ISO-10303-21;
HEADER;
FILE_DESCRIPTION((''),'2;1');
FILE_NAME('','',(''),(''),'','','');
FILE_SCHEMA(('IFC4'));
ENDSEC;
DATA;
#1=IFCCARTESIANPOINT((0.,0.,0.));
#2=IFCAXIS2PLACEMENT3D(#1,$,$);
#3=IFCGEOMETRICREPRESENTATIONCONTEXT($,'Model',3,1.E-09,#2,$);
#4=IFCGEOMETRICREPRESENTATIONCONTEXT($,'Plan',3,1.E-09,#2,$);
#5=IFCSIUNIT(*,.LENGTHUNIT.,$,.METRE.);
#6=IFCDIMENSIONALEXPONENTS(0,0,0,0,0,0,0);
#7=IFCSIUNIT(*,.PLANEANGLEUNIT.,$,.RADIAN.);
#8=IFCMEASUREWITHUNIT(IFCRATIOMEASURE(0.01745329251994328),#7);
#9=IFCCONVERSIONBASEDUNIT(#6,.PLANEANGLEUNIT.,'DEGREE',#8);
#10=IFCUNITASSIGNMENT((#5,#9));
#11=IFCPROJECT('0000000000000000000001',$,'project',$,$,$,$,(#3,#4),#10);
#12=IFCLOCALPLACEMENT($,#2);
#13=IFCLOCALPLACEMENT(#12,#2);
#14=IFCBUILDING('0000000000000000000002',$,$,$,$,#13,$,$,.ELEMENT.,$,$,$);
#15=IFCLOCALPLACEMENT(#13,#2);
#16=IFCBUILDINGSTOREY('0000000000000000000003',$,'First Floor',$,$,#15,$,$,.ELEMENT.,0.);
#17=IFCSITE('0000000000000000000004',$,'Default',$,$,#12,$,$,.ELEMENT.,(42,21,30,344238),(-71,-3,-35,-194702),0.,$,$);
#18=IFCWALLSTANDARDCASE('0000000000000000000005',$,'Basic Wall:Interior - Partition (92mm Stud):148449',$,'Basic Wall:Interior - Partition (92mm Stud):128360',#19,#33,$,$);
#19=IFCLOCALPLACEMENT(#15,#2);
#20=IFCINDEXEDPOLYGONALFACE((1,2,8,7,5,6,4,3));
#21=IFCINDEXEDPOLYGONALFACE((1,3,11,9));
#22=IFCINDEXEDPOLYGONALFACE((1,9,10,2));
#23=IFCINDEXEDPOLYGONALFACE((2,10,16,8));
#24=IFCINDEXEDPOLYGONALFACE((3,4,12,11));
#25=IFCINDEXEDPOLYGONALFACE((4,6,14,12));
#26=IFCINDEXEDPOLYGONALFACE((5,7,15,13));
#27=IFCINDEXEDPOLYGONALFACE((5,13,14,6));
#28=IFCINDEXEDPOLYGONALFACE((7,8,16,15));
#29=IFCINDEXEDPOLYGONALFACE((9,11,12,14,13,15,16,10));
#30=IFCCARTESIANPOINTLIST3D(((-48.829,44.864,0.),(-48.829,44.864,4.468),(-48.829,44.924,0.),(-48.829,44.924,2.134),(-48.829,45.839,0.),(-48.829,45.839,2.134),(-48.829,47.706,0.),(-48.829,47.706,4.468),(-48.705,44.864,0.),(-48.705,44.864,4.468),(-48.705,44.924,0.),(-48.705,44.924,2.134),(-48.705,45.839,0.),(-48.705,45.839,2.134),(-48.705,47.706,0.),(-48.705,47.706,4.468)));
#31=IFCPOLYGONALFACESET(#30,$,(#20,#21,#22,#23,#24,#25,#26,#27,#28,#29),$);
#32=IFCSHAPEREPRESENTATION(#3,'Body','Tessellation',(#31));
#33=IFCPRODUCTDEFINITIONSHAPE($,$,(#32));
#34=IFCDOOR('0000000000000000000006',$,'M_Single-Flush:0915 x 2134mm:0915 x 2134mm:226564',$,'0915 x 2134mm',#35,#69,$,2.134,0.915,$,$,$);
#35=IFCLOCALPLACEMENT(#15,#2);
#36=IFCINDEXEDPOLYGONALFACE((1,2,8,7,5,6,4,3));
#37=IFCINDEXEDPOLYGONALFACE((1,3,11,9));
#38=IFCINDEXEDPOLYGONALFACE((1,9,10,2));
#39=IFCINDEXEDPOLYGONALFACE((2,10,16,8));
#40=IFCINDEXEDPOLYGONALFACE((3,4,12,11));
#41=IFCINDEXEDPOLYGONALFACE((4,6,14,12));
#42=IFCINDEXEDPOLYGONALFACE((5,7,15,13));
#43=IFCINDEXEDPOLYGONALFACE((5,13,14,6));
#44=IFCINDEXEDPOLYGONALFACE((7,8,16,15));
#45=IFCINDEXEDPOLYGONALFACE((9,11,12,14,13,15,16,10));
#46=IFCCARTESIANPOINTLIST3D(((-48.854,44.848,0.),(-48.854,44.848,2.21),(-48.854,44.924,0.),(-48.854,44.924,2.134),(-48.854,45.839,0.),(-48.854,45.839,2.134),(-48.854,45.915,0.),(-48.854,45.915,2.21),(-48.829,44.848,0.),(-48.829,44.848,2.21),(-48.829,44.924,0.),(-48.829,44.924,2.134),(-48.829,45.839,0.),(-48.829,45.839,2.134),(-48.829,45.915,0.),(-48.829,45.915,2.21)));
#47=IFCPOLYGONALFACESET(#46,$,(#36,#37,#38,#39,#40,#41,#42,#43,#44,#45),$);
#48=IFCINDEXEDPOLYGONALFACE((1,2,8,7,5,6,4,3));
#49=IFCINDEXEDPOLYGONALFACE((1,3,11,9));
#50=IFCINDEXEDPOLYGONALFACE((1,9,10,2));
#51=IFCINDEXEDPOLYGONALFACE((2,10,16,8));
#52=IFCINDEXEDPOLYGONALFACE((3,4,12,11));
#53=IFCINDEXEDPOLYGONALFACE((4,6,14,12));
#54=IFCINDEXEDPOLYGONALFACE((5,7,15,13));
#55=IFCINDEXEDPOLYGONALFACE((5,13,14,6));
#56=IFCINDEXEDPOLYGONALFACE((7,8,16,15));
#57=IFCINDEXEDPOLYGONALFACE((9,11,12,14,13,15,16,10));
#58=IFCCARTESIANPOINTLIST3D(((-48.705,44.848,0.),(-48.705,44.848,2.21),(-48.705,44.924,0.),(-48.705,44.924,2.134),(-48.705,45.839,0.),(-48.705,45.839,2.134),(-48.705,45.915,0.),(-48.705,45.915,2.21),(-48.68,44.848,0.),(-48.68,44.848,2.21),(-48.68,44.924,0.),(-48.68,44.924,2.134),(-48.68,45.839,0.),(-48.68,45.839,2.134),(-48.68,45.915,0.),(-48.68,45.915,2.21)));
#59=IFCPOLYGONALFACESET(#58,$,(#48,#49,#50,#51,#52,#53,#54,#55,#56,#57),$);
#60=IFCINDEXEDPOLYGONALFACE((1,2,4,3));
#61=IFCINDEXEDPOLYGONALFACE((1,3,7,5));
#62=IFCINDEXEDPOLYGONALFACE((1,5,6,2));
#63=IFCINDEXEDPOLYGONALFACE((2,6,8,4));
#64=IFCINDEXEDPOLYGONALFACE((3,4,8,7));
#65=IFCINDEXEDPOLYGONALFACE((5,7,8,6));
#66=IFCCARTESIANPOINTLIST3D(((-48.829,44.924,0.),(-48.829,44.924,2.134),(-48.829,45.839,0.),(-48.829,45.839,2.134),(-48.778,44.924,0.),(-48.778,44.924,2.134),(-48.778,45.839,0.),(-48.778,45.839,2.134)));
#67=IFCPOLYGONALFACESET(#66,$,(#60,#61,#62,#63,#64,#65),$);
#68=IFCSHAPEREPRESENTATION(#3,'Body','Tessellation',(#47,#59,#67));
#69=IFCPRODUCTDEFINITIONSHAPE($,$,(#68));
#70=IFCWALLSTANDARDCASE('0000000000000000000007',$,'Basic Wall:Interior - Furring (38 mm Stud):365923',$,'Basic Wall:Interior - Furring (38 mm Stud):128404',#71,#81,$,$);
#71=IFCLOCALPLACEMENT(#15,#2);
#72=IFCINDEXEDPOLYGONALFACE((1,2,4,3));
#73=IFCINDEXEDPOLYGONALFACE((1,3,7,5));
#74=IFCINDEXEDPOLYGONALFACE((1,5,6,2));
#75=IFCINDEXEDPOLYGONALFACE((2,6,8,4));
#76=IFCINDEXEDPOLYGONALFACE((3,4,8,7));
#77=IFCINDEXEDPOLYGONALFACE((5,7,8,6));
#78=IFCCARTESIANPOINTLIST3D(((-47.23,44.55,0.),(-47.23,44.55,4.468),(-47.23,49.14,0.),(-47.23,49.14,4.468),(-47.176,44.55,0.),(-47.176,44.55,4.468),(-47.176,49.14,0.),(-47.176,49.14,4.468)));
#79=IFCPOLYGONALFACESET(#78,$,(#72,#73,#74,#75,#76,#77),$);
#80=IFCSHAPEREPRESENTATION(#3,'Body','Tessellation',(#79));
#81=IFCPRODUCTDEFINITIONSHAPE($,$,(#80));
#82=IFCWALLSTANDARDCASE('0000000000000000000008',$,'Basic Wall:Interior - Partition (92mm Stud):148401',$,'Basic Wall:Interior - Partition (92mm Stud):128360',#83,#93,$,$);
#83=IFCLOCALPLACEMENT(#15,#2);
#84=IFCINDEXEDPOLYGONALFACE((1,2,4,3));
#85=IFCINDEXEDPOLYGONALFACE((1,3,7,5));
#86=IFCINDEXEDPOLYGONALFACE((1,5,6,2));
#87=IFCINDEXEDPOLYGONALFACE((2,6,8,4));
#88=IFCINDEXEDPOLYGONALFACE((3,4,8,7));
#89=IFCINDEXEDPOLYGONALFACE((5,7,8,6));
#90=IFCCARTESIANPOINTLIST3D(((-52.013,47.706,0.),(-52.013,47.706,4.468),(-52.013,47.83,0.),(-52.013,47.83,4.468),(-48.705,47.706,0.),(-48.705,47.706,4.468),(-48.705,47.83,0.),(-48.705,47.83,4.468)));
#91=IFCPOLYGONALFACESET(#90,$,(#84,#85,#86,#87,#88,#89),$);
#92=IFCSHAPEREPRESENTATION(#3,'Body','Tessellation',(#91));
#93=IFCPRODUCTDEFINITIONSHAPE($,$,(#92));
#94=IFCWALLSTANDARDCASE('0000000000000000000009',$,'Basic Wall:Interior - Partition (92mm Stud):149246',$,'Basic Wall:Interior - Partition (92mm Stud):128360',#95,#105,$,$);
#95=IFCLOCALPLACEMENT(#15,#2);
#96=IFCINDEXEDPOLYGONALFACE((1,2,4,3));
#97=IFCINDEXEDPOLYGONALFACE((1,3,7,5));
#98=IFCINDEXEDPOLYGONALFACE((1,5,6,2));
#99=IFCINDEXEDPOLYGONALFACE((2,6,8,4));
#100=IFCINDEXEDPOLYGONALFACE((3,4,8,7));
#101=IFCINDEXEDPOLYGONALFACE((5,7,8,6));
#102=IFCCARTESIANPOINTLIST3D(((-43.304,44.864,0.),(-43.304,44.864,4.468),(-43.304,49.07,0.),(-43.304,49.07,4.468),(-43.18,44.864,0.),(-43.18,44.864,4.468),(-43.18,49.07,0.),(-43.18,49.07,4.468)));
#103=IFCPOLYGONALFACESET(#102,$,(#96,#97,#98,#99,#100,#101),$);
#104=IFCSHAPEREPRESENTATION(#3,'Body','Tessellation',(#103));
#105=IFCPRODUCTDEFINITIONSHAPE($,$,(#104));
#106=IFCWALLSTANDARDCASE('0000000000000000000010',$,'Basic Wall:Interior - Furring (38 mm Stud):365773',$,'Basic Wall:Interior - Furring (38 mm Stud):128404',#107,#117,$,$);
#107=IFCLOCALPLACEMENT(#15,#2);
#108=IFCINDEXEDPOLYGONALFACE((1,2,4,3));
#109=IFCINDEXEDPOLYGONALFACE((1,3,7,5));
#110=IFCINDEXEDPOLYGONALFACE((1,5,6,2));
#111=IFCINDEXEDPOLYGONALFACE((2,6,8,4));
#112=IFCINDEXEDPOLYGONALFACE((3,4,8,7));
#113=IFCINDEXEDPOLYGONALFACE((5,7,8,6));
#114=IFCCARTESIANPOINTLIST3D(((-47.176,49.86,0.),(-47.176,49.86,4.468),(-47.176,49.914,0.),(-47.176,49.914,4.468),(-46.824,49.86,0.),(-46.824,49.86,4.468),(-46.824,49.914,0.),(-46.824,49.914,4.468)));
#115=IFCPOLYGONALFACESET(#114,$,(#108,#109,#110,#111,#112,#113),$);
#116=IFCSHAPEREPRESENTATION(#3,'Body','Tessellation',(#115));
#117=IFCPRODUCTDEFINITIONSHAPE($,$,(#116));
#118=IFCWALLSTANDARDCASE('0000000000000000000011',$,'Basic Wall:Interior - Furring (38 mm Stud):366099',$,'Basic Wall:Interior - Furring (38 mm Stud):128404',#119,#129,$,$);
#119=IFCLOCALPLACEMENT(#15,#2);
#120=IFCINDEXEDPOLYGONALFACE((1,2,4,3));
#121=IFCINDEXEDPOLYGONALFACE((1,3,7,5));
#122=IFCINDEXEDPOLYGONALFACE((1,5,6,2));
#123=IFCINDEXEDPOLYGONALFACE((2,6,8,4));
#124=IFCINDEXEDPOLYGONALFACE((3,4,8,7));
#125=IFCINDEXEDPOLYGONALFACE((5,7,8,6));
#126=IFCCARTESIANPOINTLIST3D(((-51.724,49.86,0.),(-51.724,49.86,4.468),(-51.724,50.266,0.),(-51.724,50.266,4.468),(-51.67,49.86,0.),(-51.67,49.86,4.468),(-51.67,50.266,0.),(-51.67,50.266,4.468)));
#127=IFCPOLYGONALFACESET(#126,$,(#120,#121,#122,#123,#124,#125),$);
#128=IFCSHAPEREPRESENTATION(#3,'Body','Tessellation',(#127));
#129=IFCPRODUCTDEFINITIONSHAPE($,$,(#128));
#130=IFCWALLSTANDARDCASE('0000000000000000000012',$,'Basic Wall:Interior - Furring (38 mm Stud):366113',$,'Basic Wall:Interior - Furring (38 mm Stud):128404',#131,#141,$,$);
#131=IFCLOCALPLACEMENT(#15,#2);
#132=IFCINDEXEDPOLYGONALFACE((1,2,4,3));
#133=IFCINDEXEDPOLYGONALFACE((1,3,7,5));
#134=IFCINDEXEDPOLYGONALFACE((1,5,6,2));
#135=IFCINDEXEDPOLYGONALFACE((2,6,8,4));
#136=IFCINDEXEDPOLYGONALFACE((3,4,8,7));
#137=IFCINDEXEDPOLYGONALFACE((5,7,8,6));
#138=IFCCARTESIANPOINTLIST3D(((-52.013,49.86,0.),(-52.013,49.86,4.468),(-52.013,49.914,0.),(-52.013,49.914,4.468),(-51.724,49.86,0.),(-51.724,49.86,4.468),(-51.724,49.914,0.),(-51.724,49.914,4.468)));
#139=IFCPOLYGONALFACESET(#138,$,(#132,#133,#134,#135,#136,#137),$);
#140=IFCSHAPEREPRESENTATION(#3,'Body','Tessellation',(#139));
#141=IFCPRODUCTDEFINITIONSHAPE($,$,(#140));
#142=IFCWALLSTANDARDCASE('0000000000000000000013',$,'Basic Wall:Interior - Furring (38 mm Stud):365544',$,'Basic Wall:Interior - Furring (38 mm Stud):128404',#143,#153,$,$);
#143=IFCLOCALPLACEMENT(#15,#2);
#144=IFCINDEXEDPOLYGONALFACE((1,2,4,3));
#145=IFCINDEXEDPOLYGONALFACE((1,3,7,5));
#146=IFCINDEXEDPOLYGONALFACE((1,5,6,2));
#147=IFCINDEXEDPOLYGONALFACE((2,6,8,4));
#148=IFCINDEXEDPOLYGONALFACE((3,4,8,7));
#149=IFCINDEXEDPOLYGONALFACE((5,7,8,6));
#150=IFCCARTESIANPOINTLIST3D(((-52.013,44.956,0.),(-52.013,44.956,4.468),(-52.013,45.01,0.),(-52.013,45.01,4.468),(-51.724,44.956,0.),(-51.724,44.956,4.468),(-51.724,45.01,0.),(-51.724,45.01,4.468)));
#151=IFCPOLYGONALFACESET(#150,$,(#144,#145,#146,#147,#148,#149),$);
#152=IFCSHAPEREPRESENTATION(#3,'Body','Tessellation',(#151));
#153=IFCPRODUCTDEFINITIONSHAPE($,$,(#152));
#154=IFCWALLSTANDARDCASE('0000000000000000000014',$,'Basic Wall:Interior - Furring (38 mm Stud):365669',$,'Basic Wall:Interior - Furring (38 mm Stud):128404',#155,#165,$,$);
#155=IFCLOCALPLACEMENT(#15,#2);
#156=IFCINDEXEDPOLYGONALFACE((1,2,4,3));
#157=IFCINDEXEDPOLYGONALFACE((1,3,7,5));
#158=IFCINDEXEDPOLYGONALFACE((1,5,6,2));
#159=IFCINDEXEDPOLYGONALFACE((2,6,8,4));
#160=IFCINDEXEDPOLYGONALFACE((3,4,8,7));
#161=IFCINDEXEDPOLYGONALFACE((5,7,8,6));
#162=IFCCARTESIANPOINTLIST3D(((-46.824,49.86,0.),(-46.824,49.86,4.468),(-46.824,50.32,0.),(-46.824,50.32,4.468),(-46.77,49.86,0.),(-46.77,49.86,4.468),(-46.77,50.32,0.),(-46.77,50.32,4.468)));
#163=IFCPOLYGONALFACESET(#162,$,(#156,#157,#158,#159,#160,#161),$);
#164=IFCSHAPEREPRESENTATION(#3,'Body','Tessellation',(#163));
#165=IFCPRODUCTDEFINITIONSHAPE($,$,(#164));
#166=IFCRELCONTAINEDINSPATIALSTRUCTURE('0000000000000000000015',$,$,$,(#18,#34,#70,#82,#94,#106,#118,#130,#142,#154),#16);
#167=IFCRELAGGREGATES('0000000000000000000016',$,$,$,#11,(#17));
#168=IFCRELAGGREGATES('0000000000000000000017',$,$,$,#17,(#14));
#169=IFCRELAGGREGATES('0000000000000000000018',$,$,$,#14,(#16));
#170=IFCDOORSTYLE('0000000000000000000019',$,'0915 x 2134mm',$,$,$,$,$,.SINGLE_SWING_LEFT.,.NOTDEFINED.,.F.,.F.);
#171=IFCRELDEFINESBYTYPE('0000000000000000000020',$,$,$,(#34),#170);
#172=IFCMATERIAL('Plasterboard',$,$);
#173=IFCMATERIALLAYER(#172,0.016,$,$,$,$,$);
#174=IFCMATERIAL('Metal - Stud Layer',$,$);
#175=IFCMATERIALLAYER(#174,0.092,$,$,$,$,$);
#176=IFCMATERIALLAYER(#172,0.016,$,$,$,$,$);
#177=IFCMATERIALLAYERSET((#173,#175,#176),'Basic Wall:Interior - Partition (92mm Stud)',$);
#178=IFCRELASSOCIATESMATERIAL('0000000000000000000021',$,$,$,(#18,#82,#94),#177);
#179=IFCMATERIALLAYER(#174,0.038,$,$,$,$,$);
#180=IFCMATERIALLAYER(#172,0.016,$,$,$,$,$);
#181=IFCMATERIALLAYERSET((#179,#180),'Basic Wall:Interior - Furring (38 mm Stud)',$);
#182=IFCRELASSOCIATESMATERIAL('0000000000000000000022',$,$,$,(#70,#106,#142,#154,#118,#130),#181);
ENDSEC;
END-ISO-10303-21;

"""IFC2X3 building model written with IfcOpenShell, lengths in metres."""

from ifc_helpers import new_model, entity, si_unit, converted_unit, frame, frame_2d, origin, origin_2d_with_axis, place, context, project, spatial, polyline, rectangle, outline, extrude, source, transform, mapped, material, layer, layer_set, layer_usage, type_object, type_shapes, element, fill, save


model = new_model("IFC2X3")

# Units and contexts
model_context = context("Model", 3, precision=1e-09, world=origin())
plan_context = context("Plan", 3, precision=1e-09, world=origin())
ifc_project = project(units=[si_unit("LENGTHUNIT", "METRE"), converted_unit("PLANEANGLEUNIT", "DEGREE", entity("IfcRatioMeasure", 0.01745329251994328), si_unit("PLANEANGLEUNIT", "RADIAN"), dimensions=[0, 0, 0, 0, 0, 0, 0])], contexts=[model_context, plan_context])

# Site, building, storey
site_placement = place(None, origin())
site = spatial("IfcSite", under=ifc_project, at=site_placement, Name="Default", CompositionType="ELEMENT", RefLatitude=(42, 21, 30, 344238), RefLongitude=(-71, -3, -35, -194702), RefElevation=0.0)
building_placement = place(site_placement, origin())
building = spatial("IfcBuilding", under=site, at=building_placement, CompositionType="ELEMENT")
storey_placement = place(building_placement, origin())
storey = spatial("IfcBuildingStorey", under=building, at=storey_placement, Name="First Floor", CompositionType="ELEMENT", Elevation=0.0)

# Shared definitions
ifc_material_1 = material(Name="Plasterboard")
ifc_layer_1 = layer(ifc_material_1, 0.016)
ifc_material_2 = material(Name="Metal - Stud Layer")
ifc_layer_2 = layer(ifc_material_2, 0.092)
ifc_layer_3 = layer(ifc_material_1, 0.016)
ifc_layer_set_1 = layer_set([ifc_layer_1, ifc_layer_2, ifc_layer_3], Name="Basic Wall:Interior - Partition (92mm Stud)")
ifc_layer_usage_1 = layer_usage(ifc_layer_set_1, "AXIS2", "NEGATIVE", 0.062)

# Shared definitions
ifc_layer_4 = layer(ifc_material_2, 0.038)
ifc_layer_5 = layer(ifc_material_1, 0.016)
ifc_layer_set_2 = layer_set([ifc_layer_4, ifc_layer_5], Name="Basic Wall:Interior - Furring (38 mm Stud)")
ifc_layer_usage_2 = layer_usage(ifc_layer_set_2, "AXIS2", "NEGATIVE", 0.027)

# Wall, opening, door
wall_1_placement = place(storey_placement, frame((-48.767, 47.706, 0.0), z_axis=(0.0, 0.0, 1.0), x_axis=(0.0, -1.0, 0.0)))
wall_1 = element("IfcWallStandardCase", 1, at=wall_1_placement, inside=storey, material=ifc_layer_usage_1, Name="Basic Wall:Interior - Partition (92mm Stud):148449", ObjectType="Basic Wall:Interior - Partition (92mm Stud):128360", context=model_context, shape_type="SweptSolid", body=[
    extrude(rectangle(XDim=2.842, YDim=0.124, at=frame_2d((1.421, 0.0), x_axis=(-1.0, 0.0))), origin(), (0.0, 0.0, 1.0), 4.468),
])
opening_1_placement = place(wall_1_placement, frame((2.782, 0.062, 0.0)))
opening_1 = element("IfcOpeningElement", 2, at=opening_1_placement, cuts=wall_1, ObjectType="Opening", context=model_context, shape_type="SweptSolid", body=[
    extrude(rectangle(XDim=0.915, YDim=2.134, at=frame_2d((1.067, 0.4575), x_axis=(0.0, -1.0))), frame((0.0, 0.0, 0.0), z_axis=(0.0, -1.0, 0.0), x_axis=(0.0, 0.0, 1.0)), (0.0, 0.0, 1.0), 0.124),
])
door_style_1 = type_object("IfcDoorStyle", Name="0915 x 2134mm", ConstructionType="NOTDEFINED", OperationType="SINGLE_SWING_LEFT", ParameterTakesPrecedence=False, Sizeable=False)
shared_shape_1 = source(origin(), model_context, "Body", "SweptSolid", [
    extrude(outline(polyline([(-0.5335, -1.124), (0.5335, -1.124), (0.5335, 1.086), (0.4575, 1.086), (0.4575, -1.048), (-0.4575, -1.048), (-0.4575, 1.086), (-0.5335, 1.086), (-0.5335, -1.124)])), frame((0.4575, 0.149, 1.086), z_axis=(0.0, -1.0, 0.0), x_axis=(-1.0, 0.0, 0.0)), (0.0, 0.0, 1.0), 0.025),
    extrude(outline(polyline([(-1.124, -0.5335), (1.086, -0.5335), (1.086, -0.4575), (-1.048, -0.4575), (-1.048, 0.4575), (1.086, 0.4575), (1.086, 0.5335), (-1.124, 0.5335), (-1.124, -0.5335)])), frame((0.4575, 0.0, 1.086), z_axis=(0.0, -1.0, 0.0), x_axis=(0.0, 0.0, -1.0)), (0.0, 0.0, 1.0), 0.025),
    extrude(rectangle(XDim=0.915, YDim=0.051, at=origin_2d_with_axis()), frame((0.4575, 0.0985, 0.0)), (0.0, 0.0, 1.0), 2.134),
])
type_shapes(door_style_1, [shared_shape_1])
door_1_placement = place(opening_1_placement, frame((0.0, 0.0, 0.0), z_axis=(0.0, 0.0, 1.0), x_axis=(-1.0, 0.0, 0.0)))
door_1 = element("IfcDoor", 3, at=door_1_placement, inside=storey, type_object=door_style_1, Name="M_Single-Flush:0915 x 2134mm:0915 x 2134mm:226564", ObjectType="0915 x 2134mm", OverallHeight=2.134, OverallWidth=0.915, context=model_context, shape_type="MappedRepresentation", body=[
    mapped(shared_shape_1, transform((0.0, 0.0, 0.0), scale=1.0)),
])
fill(opening_1, door_1)

# Walls
wall_2_placement = place(storey_placement, frame((-47.203, 49.14, 0.0), z_axis=(0.0, 0.0, 1.0), x_axis=(0.0, -1.0, 0.0)))
element("IfcWallStandardCase", 4, at=wall_2_placement, inside=storey, material=ifc_layer_usage_2, Name="Basic Wall:Interior - Furring (38 mm Stud):365923", ObjectType="Basic Wall:Interior - Furring (38 mm Stud):128404", context=model_context, shape_type="SweptSolid", body=[
    extrude(rectangle(XDim=4.59, YDim=0.054, at=frame_2d((2.295, 0.0), x_axis=(-1.0, 0.0))), origin(), (0.0, 0.0, 1.0), 4.468),
])
wall_3_placement = place(storey_placement, frame((-52.013, 47.768, 0.0)))
element("IfcWallStandardCase", 5, at=wall_3_placement, inside=storey, material=ifc_layer_usage_1, Name="Basic Wall:Interior - Partition (92mm Stud):148401", ObjectType="Basic Wall:Interior - Partition (92mm Stud):128360", context=model_context, shape_type="SweptSolid", body=[
    extrude(rectangle(XDim=3.308, YDim=0.124, at=frame_2d((1.654, 0.0), x_axis=(-1.0, 0.0))), origin(), (0.0, 0.0, 1.0), 4.468),
])
wall_4_placement = place(storey_placement, frame((-43.242, 49.07, 0.0), z_axis=(0.0, 0.0, 1.0), x_axis=(0.0, -1.0, 0.0)))
element("IfcWallStandardCase", 6, at=wall_4_placement, inside=storey, material=ifc_layer_usage_1, Name="Basic Wall:Interior - Partition (92mm Stud):149246", ObjectType="Basic Wall:Interior - Partition (92mm Stud):128360", context=model_context, shape_type="SweptSolid", body=[
    extrude(rectangle(XDim=4.206, YDim=0.124, at=frame_2d((2.103, 0.0), x_axis=(-1.0, 0.0))), origin(), (0.0, 0.0, 1.0), 4.468),
])
wall_5_placement = place(storey_placement, frame((-47.176, 49.887, 0.0)))
element("IfcWallStandardCase", 7, at=wall_5_placement, inside=storey, material=ifc_layer_usage_2, Name="Basic Wall:Interior - Furring (38 mm Stud):365773", ObjectType="Basic Wall:Interior - Furring (38 mm Stud):128404", context=model_context, shape_type="SweptSolid", body=[
    extrude(rectangle(XDim=0.352, YDim=0.054, at=frame_2d((0.176, 0.0), x_axis=(-1.0, 0.0))), origin(), (0.0, 0.0, 1.0), 4.468),
])
ifc_layer_usage_3 = layer_usage(ifc_layer_set_2, "AXIS2", "POSITIVE", -0.027)
wall_6_placement = place(storey_placement, frame((-51.697, 50.266, 0.0), z_axis=(0.0, 0.0, 1.0), x_axis=(0.0, -1.0, 0.0)))
element("IfcWallStandardCase", 8, at=wall_6_placement, inside=storey, material=ifc_layer_usage_3, Name="Basic Wall:Interior - Furring (38 mm Stud):366099", ObjectType="Basic Wall:Interior - Furring (38 mm Stud):128404", context=model_context, shape_type="SweptSolid", body=[
    extrude(rectangle(XDim=0.406, YDim=0.054, at=frame_2d((0.203, 0.0), x_axis=(-1.0, 0.0))), origin(), (0.0, 0.0, 1.0), 4.468),
])
wall_7_placement = place(storey_placement, frame((-51.724, 49.887, 0.0), z_axis=(0.0, 0.0, 1.0), x_axis=(-1.0, 0.0, 0.0)))
element("IfcWallStandardCase", 9, at=wall_7_placement, inside=storey, material=ifc_layer_usage_3, Name="Basic Wall:Interior - Furring (38 mm Stud):366113", ObjectType="Basic Wall:Interior - Furring (38 mm Stud):128404", context=model_context, shape_type="SweptSolid", body=[
    extrude(rectangle(XDim=0.289, YDim=0.054, at=frame_2d((0.1445, 0.0), x_axis=(-1.0, 0.0))), origin(), (0.0, 0.0, 1.0), 4.468),
])
wall_8_placement = place(storey_placement, frame((-51.724, 44.983, 0.0), z_axis=(0.0, 0.0, 1.0), x_axis=(-1.0, 0.0, 0.0)))
element("IfcWallStandardCase", 10, at=wall_8_placement, inside=storey, material=ifc_layer_usage_2, Name="Basic Wall:Interior - Furring (38 mm Stud):365544", ObjectType="Basic Wall:Interior - Furring (38 mm Stud):128404", context=model_context, shape_type="SweptSolid", body=[
    extrude(rectangle(XDim=0.289, YDim=0.054, at=frame_2d((0.1445, 0.0), x_axis=(-1.0, 0.0))), origin(), (0.0, 0.0, 1.0), 4.468),
])
wall_9_placement = place(storey_placement, frame((-46.797, 49.86, 0.0), z_axis=(0.0, 0.0, 1.0), x_axis=(0.0, 1.0, 0.0)))
element("IfcWallStandardCase", 11, at=wall_9_placement, inside=storey, material=ifc_layer_usage_2, Name="Basic Wall:Interior - Furring (38 mm Stud):365669", ObjectType="Basic Wall:Interior - Furring (38 mm Stud):128404", context=model_context, shape_type="SweptSolid", body=[
    extrude(rectangle(XDim=0.46, YDim=0.054, at=frame_2d((0.23, 0.0), x_axis=(-1.0, 0.0))), origin(), (0.0, 0.0, 1.0), 4.468),
])

save(model, "model.ifc")
